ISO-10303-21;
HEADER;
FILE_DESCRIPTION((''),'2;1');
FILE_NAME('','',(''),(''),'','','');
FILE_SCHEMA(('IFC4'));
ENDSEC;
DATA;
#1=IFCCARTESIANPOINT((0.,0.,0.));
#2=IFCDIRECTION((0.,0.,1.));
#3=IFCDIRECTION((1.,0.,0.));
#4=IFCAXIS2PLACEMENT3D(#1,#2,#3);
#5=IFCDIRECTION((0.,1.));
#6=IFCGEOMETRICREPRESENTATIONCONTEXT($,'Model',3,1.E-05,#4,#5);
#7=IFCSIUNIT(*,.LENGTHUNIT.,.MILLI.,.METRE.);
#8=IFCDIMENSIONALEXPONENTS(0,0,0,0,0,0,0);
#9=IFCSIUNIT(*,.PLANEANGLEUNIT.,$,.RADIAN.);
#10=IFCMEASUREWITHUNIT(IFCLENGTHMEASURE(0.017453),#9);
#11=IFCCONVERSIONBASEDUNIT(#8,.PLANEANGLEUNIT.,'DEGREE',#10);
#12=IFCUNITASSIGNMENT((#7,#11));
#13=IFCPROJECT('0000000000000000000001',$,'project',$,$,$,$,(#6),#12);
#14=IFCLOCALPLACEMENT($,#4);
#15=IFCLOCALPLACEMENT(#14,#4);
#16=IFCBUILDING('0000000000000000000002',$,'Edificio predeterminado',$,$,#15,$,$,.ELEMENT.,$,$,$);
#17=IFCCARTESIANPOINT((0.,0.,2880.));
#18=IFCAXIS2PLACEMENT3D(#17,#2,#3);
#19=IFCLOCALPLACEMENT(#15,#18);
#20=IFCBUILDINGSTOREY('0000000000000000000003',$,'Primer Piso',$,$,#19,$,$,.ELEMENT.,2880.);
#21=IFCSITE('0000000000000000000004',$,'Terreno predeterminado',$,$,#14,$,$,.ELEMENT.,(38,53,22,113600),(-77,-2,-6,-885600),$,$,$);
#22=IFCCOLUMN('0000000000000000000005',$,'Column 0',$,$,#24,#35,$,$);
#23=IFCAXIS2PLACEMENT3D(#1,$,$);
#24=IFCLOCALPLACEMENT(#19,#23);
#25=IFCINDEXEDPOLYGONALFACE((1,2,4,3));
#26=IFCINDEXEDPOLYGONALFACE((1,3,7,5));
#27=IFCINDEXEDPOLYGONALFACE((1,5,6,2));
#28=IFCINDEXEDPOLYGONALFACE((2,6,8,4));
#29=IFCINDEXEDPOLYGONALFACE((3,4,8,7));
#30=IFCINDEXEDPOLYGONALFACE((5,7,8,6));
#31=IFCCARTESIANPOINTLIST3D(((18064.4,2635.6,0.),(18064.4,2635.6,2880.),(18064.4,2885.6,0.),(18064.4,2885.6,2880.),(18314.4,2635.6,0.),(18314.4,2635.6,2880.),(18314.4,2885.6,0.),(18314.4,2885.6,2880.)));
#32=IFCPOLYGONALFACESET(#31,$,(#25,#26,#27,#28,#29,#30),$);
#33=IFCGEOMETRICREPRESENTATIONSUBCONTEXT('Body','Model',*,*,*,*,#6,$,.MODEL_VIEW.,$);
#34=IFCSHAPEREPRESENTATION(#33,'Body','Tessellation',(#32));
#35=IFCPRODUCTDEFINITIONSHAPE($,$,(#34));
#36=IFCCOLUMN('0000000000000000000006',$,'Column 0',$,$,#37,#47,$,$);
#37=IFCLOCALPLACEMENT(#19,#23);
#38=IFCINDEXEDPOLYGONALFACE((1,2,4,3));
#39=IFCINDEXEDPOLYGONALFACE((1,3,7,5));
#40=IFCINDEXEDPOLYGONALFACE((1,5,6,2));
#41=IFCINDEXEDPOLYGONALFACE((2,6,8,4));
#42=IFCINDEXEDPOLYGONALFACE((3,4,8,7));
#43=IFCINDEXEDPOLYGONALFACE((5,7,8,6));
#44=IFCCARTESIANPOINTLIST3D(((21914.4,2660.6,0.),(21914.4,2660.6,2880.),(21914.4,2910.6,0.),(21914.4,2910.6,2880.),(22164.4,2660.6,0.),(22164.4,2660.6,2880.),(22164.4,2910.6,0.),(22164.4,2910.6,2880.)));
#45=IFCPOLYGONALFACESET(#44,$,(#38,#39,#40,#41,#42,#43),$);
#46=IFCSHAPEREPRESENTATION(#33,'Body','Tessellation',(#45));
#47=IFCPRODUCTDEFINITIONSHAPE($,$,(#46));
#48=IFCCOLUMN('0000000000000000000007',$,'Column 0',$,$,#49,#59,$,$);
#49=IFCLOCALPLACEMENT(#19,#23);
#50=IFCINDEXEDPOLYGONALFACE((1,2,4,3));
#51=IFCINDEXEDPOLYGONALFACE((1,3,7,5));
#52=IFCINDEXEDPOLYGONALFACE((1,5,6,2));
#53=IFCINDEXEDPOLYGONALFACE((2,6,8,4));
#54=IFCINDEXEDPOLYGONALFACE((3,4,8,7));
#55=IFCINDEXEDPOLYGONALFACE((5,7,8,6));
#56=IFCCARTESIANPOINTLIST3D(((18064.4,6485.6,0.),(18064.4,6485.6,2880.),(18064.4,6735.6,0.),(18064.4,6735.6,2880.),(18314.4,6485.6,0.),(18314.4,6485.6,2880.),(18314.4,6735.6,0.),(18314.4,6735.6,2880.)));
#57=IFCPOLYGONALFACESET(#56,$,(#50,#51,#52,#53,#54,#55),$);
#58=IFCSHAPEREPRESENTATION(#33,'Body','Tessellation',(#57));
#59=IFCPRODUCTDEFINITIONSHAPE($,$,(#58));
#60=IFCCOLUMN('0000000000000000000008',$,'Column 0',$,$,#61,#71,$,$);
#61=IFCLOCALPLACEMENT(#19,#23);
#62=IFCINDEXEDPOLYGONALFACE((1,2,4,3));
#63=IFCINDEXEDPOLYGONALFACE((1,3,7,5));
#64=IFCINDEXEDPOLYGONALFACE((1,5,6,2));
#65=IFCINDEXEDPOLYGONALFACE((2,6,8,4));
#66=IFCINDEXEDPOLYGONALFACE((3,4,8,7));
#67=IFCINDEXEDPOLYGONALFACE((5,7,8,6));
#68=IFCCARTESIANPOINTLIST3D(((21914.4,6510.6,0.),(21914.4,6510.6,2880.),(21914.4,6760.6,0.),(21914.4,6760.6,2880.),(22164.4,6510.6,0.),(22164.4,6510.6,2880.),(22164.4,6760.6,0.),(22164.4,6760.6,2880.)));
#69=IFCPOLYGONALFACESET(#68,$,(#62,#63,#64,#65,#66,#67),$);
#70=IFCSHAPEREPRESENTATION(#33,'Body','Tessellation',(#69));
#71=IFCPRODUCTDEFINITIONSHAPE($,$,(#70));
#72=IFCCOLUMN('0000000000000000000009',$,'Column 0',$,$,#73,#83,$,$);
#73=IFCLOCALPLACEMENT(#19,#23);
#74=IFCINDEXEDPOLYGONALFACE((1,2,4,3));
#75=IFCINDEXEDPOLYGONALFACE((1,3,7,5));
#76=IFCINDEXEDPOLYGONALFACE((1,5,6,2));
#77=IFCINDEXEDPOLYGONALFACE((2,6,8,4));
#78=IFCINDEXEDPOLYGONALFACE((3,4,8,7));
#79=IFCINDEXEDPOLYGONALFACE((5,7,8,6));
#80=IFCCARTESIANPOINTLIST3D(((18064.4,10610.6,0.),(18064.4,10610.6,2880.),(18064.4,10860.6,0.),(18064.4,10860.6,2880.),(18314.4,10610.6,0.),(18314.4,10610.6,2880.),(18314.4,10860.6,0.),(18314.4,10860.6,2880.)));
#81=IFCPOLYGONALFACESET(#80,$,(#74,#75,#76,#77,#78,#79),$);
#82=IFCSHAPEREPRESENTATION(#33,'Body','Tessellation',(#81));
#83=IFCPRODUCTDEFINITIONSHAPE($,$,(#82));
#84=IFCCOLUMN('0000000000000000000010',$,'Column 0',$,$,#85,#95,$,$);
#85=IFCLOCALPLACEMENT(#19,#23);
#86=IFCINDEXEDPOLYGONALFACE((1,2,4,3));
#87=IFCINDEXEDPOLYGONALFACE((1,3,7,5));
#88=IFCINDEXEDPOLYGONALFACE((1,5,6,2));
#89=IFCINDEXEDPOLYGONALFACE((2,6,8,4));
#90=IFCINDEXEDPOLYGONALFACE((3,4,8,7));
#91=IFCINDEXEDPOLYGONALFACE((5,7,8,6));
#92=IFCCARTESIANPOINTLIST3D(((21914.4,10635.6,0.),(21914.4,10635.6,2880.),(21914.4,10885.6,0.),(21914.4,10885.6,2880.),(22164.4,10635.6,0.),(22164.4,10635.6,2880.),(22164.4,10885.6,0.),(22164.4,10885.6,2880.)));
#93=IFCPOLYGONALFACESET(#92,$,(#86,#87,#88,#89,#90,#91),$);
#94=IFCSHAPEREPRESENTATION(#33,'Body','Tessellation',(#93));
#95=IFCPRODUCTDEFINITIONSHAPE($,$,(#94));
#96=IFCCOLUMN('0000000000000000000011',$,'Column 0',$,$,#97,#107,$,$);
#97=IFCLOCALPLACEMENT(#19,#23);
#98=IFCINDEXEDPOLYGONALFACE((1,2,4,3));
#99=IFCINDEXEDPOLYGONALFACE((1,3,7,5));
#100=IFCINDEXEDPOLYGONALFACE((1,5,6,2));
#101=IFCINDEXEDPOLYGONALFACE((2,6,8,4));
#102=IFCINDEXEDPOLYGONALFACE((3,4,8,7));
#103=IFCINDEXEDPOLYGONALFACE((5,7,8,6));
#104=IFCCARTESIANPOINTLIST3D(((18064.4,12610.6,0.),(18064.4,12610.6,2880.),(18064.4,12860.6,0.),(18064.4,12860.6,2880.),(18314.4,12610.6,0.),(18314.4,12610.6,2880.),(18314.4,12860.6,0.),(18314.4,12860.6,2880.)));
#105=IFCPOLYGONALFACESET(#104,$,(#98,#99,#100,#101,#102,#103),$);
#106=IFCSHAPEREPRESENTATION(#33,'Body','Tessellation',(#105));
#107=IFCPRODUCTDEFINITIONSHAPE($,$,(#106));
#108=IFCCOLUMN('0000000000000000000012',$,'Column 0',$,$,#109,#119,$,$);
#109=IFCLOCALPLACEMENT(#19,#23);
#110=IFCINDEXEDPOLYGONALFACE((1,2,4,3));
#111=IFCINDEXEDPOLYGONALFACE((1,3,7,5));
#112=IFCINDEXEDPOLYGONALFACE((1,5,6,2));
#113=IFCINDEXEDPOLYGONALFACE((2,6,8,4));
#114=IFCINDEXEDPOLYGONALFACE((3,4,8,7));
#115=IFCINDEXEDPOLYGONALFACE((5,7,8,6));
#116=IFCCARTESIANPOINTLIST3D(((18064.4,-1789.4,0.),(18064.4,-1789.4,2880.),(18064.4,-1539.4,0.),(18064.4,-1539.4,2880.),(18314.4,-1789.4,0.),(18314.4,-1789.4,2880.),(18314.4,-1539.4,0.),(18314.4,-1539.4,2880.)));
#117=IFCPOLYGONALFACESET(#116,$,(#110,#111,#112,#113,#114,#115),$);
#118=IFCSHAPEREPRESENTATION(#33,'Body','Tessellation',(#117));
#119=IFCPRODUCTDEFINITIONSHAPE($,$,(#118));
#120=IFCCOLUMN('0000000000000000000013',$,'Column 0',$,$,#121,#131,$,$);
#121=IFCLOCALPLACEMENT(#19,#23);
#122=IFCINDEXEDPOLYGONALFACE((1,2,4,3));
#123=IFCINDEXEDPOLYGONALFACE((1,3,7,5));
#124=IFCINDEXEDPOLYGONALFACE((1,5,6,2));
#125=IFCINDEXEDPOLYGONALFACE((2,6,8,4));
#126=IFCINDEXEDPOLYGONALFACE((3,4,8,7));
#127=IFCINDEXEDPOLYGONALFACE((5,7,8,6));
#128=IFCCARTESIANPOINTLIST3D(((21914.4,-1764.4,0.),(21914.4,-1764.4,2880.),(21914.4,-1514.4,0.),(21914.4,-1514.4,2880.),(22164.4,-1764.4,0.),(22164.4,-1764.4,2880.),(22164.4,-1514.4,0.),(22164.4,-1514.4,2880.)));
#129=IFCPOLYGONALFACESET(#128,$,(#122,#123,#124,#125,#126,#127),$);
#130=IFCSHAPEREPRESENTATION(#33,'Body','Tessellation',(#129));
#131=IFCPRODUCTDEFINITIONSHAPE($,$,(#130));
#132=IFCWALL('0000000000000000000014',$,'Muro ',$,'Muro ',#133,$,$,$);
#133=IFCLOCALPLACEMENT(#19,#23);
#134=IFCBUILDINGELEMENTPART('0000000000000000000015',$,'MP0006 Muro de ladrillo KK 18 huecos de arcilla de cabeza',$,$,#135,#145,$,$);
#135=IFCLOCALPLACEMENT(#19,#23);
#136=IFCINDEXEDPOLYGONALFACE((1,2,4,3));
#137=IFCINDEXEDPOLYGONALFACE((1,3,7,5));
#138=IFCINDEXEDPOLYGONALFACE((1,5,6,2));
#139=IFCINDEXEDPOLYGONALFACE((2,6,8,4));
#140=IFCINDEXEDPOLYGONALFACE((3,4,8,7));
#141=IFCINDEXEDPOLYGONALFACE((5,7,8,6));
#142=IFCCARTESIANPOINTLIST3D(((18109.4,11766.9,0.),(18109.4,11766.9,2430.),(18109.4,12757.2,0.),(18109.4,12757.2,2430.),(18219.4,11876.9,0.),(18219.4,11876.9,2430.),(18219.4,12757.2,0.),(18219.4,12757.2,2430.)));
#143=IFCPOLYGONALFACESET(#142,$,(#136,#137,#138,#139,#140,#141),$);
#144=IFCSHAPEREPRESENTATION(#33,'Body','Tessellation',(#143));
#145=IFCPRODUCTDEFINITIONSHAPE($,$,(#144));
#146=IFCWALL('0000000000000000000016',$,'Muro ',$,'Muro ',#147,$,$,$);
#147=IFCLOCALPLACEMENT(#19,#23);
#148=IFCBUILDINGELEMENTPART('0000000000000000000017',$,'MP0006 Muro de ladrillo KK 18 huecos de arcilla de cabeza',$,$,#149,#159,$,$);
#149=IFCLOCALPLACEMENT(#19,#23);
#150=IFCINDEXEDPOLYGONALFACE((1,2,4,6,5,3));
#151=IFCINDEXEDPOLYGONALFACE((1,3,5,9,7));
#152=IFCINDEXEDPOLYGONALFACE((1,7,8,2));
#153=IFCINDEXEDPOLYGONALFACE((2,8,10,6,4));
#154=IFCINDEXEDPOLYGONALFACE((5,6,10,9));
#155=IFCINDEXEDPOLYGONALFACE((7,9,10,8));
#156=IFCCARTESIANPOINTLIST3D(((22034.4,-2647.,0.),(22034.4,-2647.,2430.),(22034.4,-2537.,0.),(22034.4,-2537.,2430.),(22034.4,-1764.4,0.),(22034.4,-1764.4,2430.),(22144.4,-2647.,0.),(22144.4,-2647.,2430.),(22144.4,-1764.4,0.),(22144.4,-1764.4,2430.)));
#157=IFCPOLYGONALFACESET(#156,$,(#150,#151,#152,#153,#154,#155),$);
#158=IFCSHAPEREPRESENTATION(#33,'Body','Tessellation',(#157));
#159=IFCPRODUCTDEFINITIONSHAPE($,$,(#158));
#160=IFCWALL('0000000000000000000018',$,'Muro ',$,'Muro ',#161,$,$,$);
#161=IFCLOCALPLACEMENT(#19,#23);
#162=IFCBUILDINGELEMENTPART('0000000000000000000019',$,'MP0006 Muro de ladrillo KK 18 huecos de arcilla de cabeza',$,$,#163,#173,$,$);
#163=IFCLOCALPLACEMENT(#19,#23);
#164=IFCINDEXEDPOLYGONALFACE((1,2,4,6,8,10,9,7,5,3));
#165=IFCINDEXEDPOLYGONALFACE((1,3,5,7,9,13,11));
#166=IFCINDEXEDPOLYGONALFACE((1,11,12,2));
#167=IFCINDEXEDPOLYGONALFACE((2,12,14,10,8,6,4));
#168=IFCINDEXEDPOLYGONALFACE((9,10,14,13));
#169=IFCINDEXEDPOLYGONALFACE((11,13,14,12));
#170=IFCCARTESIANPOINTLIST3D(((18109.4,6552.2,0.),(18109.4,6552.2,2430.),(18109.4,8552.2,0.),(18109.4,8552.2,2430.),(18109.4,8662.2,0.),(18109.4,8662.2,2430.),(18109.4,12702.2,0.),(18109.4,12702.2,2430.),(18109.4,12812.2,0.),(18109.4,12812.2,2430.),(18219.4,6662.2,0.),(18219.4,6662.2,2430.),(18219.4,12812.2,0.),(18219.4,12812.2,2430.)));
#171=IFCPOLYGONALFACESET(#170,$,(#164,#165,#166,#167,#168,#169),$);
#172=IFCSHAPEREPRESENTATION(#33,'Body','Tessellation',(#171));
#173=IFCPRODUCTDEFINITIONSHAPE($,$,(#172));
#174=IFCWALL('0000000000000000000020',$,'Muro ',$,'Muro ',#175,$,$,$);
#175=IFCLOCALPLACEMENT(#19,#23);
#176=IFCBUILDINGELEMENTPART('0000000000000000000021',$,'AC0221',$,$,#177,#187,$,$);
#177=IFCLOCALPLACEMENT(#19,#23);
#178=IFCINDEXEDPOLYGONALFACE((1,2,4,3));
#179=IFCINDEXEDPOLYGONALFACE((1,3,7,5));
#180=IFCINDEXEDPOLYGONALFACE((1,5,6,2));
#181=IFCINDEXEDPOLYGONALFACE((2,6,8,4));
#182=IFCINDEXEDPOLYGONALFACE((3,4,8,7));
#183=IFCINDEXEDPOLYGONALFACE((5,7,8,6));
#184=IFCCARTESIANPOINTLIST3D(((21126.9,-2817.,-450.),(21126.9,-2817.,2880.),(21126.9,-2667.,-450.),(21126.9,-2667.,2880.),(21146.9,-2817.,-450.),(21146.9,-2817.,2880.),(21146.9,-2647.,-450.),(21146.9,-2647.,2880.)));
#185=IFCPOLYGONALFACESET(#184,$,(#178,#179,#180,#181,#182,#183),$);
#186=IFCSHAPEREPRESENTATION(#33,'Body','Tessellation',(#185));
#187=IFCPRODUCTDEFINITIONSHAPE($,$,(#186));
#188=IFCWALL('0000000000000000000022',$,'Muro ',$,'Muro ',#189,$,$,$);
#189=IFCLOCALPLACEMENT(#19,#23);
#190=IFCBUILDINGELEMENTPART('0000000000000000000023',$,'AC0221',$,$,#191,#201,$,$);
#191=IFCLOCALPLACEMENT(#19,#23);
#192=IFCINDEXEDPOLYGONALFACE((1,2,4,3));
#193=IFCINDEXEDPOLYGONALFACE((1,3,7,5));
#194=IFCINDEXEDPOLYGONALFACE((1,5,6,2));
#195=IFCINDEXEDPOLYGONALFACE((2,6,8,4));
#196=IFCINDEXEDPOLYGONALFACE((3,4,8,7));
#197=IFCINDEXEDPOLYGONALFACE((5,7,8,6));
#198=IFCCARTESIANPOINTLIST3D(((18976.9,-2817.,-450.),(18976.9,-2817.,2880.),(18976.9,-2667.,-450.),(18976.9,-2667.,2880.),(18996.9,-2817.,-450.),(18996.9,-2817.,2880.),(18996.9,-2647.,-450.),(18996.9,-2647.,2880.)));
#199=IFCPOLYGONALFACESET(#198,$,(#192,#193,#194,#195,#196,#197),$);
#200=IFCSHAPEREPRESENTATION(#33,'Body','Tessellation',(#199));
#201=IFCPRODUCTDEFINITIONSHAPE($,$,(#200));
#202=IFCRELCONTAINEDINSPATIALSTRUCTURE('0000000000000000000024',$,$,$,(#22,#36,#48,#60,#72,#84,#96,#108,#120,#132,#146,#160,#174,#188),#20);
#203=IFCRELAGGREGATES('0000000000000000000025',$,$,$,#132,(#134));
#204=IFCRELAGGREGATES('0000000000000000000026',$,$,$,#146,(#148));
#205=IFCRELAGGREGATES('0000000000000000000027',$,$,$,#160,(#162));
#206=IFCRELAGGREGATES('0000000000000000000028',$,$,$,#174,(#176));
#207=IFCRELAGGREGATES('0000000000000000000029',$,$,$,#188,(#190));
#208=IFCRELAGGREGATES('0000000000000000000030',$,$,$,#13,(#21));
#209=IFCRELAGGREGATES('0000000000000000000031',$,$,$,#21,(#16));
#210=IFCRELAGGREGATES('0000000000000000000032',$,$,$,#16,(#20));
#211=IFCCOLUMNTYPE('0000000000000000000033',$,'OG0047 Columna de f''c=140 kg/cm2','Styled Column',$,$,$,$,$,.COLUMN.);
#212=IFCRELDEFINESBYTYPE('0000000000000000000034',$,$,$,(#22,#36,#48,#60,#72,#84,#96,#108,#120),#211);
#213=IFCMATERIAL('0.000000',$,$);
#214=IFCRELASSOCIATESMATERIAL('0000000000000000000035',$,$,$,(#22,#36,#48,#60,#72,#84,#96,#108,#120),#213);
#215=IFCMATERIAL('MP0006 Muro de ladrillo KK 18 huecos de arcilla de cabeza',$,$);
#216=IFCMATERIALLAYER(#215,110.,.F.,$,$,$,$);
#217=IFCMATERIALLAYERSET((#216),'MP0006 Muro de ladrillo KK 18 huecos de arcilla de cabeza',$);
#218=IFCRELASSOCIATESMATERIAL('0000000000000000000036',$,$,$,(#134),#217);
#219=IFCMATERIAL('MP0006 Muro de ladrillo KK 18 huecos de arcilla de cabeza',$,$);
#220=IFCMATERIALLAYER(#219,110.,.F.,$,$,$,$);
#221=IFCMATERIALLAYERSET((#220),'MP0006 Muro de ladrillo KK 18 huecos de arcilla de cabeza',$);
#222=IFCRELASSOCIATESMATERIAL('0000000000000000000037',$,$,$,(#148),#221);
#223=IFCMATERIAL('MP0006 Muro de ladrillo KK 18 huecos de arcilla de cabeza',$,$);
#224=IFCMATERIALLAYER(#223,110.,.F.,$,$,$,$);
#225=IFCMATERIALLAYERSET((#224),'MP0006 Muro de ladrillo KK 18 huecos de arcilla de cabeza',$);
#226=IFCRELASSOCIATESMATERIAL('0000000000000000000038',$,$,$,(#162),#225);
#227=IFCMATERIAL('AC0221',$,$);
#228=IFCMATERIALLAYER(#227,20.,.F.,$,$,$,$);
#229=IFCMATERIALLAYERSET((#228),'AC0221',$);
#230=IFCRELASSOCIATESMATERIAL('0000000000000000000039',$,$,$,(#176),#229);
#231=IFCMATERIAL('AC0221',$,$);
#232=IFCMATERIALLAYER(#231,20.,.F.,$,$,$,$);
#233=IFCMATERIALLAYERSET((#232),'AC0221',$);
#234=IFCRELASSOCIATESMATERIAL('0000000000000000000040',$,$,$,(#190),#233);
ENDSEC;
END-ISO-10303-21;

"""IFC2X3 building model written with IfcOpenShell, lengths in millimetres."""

from ifc_helpers import new_model, entity, si_unit, converted_unit, direction, frame, origin_with_axes, place, context, subcontext, project, spatial, polyline, outline, extrude, clip, bounded_halfspace, material, layer, layer_set, layer_usage, type_object, element, aggregate, save


model = new_model("IFC2X3")

# Units and contexts
model_context = context("Model", 3, precision=1e-05, world=origin_with_axes(), true_north=direction((0.0, 1.0)))
body_context = subcontext(model_context, "Body", "Model", "MODEL_VIEW")
ifc_project = project(units=[si_unit("LENGTHUNIT", "METRE", prefix="MILLI"), converted_unit("PLANEANGLEUNIT", "DEGREE", entity("IfcLengthMeasure", 0.017453), si_unit("PLANEANGLEUNIT", "RADIAN"), dimensions=[0, 0, 0, 0, 0, 0, 0])], contexts=[model_context])

# Site, building, storey
site_placement = place(None, origin_with_axes())
site = spatial("IfcSite", under=ifc_project, at=site_placement, Name="Terreno predeterminado", CompositionType="ELEMENT", RefLatitude=(38, 53, 22, 113600), RefLongitude=(-77, -2, -6, -885600))
building_placement = place(site_placement, origin_with_axes())
building = spatial("IfcBuilding", under=site, at=building_placement, Name="Edificio predeterminado", CompositionType="ELEMENT")
storey_placement = place(building_placement, frame((0.0, 0.0, 2880.0), z_axis=(0.0, 0.0, 1.0), x_axis=(1.0, 0.0, 0.0)))
storey = spatial("IfcBuildingStorey", under=building, at=storey_placement, Name="Primer Piso", CompositionType="ELEMENT", Elevation=2880.0)

# Columns
ifc_material_1 = material(Name="0.000000")
column_type = type_object("IfcColumnType", Name="OG0047 Columna de f'c=140 kg/cm2", Description="Styled Column", PredefinedType="COLUMN")
for number, where, z_axis, x_axis, name in (
    (1, (18189.4, 2760.6, 0.0), (0.0, 0.0, 1.0), (1.0, 0.0, 0.0), "Column 0"),
    (2, (22039.4, 2785.6, 0.0), (0.0, 0.0, 1.0), (1.0, 0.0, 0.0), "Column 0"),
    (3, (18189.4, 6610.6, 0.0), (0.0, 0.0, 1.0), (1.0, 0.0, 0.0), "Column 0"),
    (4, (22039.4, 6635.6, 0.0), (0.0, 0.0, 1.0), (1.0, 0.0, 0.0), "Column 0"),
    (5, (18189.4, 10735.6, 0.0), (0.0, 0.0, 1.0), (1.0, 0.0, 0.0), "Column 0"),
    (6, (22039.4, 10760.6, 0.0), (0.0, 0.0, 1.0), (1.0, 0.0, 0.0), "Column 0"),
    (7, (18189.4, 12735.6, 0.0), (0.0, 0.0, 1.0), (1.0, 0.0, 0.0), "Column 0"),
    (8, (18189.4, -1664.4, 0.0), (0.0, 0.0, 1.0), (1.0, 0.0, 0.0), "Column 0"),
    (9, (22039.4, -1639.4, 0.0), (0.0, 0.0, 1.0), (1.0, 0.0, 0.0), "Column 0"),
):
    element("IfcColumn", number, at=place(storey_placement, frame(where, z_axis=z_axis, x_axis=x_axis)), inside=storey, type_object=column_type, material=ifc_material_1, Name=name, context=body_context, shape_type="SweptSolid", body=[
        extrude(outline(polyline([(-125.0, -125.0), (125.0, -125.0), (125.0, 125.0), (-125.0, 125.0), (-125.0, -125.0)])), origin_with_axes(), (0.0, 0.0, 1.0), 2880.0),
    ])

# Walls, building element parts
wall_1_placement = place(storey_placement, frame((18164.4, 11821.9, 0.0), z_axis=(0.0, 0.0, 1.0), x_axis=(0.0, 1.0, 0.0)))
wall_1 = element("IfcWall", 10, at=wall_1_placement, inside=storey, Name="Muro ", ObjectType="Muro ")
ifc_material_2 = material(Name="MP0006 Muro de ladrillo KK 18 huecos de arcilla de cabeza")
ifc_layer_1 = layer(ifc_material_2, 110.0, ventilated=False)
ifc_layer_set_1 = layer_set([ifc_layer_1], Name="MP0006 Muro de ladrillo KK 18 huecos de arcilla de cabeza")
ifc_layer_usage_1 = layer_usage(ifc_layer_set_1, "AXIS2", "NEGATIVE", -55.0)
building_element_part_1_placement = place(wall_1_placement, origin_with_axes())
building_element_part_1 = element("IfcBuildingElementPart", 11, at=building_element_part_1_placement, material=ifc_layer_usage_1, Name="MP0006 Muro de ladrillo KK 18 huecos de arcilla de cabeza", context=body_context, shape_type="SweptSolid", body=[
    extrude(outline(polyline([(935.2, 55.0), (935.2, -55.0), (55.0, -55.0), (-55.0, 55.0), (935.2, 55.0)])), origin_with_axes(), (0.0, 0.0, 1.0), 2430.0),
])
aggregate(wall_1, [building_element_part_1])
wall_2_placement = place(storey_placement, frame((22089.4, -1764.4, 0.0), z_axis=(0.0, 0.0, 1.0), x_axis=(0.0, -1.0, 0.0)))
wall_2 = element("IfcWall", 12, at=wall_2_placement, inside=storey, Name="Muro ", ObjectType="Muro ")
ifc_material_3 = material(Name="MP0006 Muro de ladrillo KK 18 huecos de arcilla de cabeza")
ifc_layer_2 = layer(ifc_material_3, 110.0, ventilated=False)
ifc_layer_set_2 = layer_set([ifc_layer_2], Name="MP0006 Muro de ladrillo KK 18 huecos de arcilla de cabeza")
ifc_layer_usage_2 = layer_usage(ifc_layer_set_2, "AXIS2", "NEGATIVE", -55.0)
building_element_part_2_placement = place(wall_2_placement, origin_with_axes())
building_element_part_2 = element("IfcBuildingElementPart", 13, at=building_element_part_2_placement, material=ifc_layer_usage_2, Name="MP0006 Muro de ladrillo KK 18 huecos de arcilla de cabeza", context=body_context, shape_type="SweptSolid", body=[
    extrude(outline(polyline([(882.6, 55.0), (882.6, -55.0), (772.6, -55.0), (0.0, -55.0), (0.0, 55.0), (882.6, 55.0)])), origin_with_axes(), (0.0, 0.0, 1.0), 2430.0),
])
aggregate(wall_2, [building_element_part_2])
wall_3_placement = place(storey_placement, frame((18164.4, 12757.2, 0.0), z_axis=(0.0, 0.0, 1.0), x_axis=(0.0, -1.0, 0.0)))
wall_3 = element("IfcWall", 14, at=wall_3_placement, inside=storey, Name="Muro ", ObjectType="Muro ")
ifc_material_4 = material(Name="MP0006 Muro de ladrillo KK 18 huecos de arcilla de cabeza")
ifc_layer_3 = layer(ifc_material_4, 110.0, ventilated=False)
ifc_layer_set_3 = layer_set([ifc_layer_3], Name="MP0006 Muro de ladrillo KK 18 huecos de arcilla de cabeza")
ifc_layer_usage_3 = layer_usage(ifc_layer_set_3, "AXIS2", "NEGATIVE", -55.0)
building_element_part_3_placement = place(wall_3_placement, origin_with_axes())
building_element_part_3 = element("IfcBuildingElementPart", 15, at=building_element_part_3_placement, material=ifc_layer_usage_3, Name="MP0006 Muro de ladrillo KK 18 huecos de arcilla de cabeza", context=body_context, shape_type="SweptSolid", body=[
    extrude(outline(polyline([(6095.0, 55.0), (6205.0, -55.0), (4205.0, -55.0), (4095.0, -55.0), (55.0, -55.0), (-55.0, -55.0), (-55.0, 55.0), (6095.0, 55.0)])), origin_with_axes(), (0.0, 0.0, 1.0), 2430.0),
])
aggregate(wall_3, [building_element_part_3])
wall_4_placement = place(storey_placement, frame((21201.9, -2817.0, 0.0), z_axis=(0.0, 0.0, 1.0), x_axis=(0.0, 1.0, 0.0)))
wall_4 = element("IfcWall", 16, at=wall_4_placement, inside=storey, Name="Muro ", ObjectType="Muro ")
ifc_material_5 = material(Name="AC0221")
ifc_layer_4 = layer(ifc_material_5, 20.0, ventilated=False)
ifc_layer_set_4 = layer_set([ifc_layer_4], Name="AC0221")
ifc_layer_usage_4 = layer_usage(ifc_layer_set_4, "AXIS2", "NEGATIVE", -75.0)
building_element_part_4_placement = place(wall_4_placement, origin_with_axes())
building_element_part_4 = element("IfcBuildingElementPart", 17, at=building_element_part_4_placement, material=ifc_layer_usage_4, Name="AC0221", context=body_context, shape_type="Clipping", body=[
    clip(clip(extrude(outline(polyline([(150.0, 75.0), (170.0, 55.0), (0.0, 55.0), (0.0, 75.0), (150.0, 75.0)])), frame((0.0, 0.0, -450.0), z_axis=(0.0, 0.0, 1.0), x_axis=(1.0, 0.0, 0.0)), (0.0, 0.0, 1.0), 3330.0), bounded_halfspace(frame((0.0, 0.0, -450.0), z_axis=(0.0, 0.0, 1.0), x_axis=(1.0, 0.0, 0.0)), True, origin_with_axes(), polyline([(-150.0, -150.0), (375.0, -150.0), (375.0, 150.0), (-150.0, 150.0), (-150.0, -150.0)]))), bounded_halfspace(frame((0.0, 0.0, 2880.0), z_axis=(0.0, 0.0, 1.0), x_axis=(1.0, 0.0, 0.0)), False, origin_with_axes(), polyline([(-150.0, -150.0), (375.0, -150.0), (375.0, 150.0), (-150.0, 150.0), (-150.0, -150.0)]))),
])
aggregate(wall_4, [building_element_part_4])
wall_5_placement = place(storey_placement, frame((19051.9, -2817.0, 0.0), z_axis=(0.0, 0.0, 1.0), x_axis=(0.0, 1.0, 0.0)))
wall_5 = element("IfcWall", 18, at=wall_5_placement, inside=storey, Name="Muro ", ObjectType="Muro ")
ifc_material_6 = material(Name="AC0221")
ifc_layer_5 = layer(ifc_material_6, 20.0, ventilated=False)
ifc_layer_set_5 = layer_set([ifc_layer_5], Name="AC0221")
ifc_layer_usage_5 = layer_usage(ifc_layer_set_5, "AXIS2", "NEGATIVE", -75.0)
building_element_part_5_placement = place(wall_5_placement, origin_with_axes())
building_element_part_5 = element("IfcBuildingElementPart", 19, at=building_element_part_5_placement, material=ifc_layer_usage_5, Name="AC0221", context=body_context, shape_type="Clipping", body=[
    clip(clip(extrude(outline(polyline([(150.0, 75.0), (170.0, 55.0), (0.0, 55.0), (0.0, 75.0), (150.0, 75.0)])), frame((0.0, 0.0, -450.0), z_axis=(0.0, 0.0, 1.0), x_axis=(1.0, 0.0, 0.0)), (0.0, 0.0, 1.0), 3330.0), bounded_halfspace(frame((0.0, 0.0, -450.0), z_axis=(0.0, 0.0, 1.0), x_axis=(1.0, 0.0, 0.0)), True, origin_with_axes(), polyline([(-150.0, -150.0), (375.0, -150.0), (375.0, 150.0), (-150.0, 150.0), (-150.0, -150.0)]))), bounded_halfspace(frame((0.0, 0.0, 2880.0), z_axis=(0.0, 0.0, 1.0), x_axis=(1.0, 0.0, 0.0)), False, origin_with_axes(), polyline([(-150.0, -150.0), (375.0, -150.0), (375.0, 150.0), (-150.0, 150.0), (-150.0, -150.0)]))),
])
aggregate(wall_5, [building_element_part_5])

save(model, "model.ifc")
